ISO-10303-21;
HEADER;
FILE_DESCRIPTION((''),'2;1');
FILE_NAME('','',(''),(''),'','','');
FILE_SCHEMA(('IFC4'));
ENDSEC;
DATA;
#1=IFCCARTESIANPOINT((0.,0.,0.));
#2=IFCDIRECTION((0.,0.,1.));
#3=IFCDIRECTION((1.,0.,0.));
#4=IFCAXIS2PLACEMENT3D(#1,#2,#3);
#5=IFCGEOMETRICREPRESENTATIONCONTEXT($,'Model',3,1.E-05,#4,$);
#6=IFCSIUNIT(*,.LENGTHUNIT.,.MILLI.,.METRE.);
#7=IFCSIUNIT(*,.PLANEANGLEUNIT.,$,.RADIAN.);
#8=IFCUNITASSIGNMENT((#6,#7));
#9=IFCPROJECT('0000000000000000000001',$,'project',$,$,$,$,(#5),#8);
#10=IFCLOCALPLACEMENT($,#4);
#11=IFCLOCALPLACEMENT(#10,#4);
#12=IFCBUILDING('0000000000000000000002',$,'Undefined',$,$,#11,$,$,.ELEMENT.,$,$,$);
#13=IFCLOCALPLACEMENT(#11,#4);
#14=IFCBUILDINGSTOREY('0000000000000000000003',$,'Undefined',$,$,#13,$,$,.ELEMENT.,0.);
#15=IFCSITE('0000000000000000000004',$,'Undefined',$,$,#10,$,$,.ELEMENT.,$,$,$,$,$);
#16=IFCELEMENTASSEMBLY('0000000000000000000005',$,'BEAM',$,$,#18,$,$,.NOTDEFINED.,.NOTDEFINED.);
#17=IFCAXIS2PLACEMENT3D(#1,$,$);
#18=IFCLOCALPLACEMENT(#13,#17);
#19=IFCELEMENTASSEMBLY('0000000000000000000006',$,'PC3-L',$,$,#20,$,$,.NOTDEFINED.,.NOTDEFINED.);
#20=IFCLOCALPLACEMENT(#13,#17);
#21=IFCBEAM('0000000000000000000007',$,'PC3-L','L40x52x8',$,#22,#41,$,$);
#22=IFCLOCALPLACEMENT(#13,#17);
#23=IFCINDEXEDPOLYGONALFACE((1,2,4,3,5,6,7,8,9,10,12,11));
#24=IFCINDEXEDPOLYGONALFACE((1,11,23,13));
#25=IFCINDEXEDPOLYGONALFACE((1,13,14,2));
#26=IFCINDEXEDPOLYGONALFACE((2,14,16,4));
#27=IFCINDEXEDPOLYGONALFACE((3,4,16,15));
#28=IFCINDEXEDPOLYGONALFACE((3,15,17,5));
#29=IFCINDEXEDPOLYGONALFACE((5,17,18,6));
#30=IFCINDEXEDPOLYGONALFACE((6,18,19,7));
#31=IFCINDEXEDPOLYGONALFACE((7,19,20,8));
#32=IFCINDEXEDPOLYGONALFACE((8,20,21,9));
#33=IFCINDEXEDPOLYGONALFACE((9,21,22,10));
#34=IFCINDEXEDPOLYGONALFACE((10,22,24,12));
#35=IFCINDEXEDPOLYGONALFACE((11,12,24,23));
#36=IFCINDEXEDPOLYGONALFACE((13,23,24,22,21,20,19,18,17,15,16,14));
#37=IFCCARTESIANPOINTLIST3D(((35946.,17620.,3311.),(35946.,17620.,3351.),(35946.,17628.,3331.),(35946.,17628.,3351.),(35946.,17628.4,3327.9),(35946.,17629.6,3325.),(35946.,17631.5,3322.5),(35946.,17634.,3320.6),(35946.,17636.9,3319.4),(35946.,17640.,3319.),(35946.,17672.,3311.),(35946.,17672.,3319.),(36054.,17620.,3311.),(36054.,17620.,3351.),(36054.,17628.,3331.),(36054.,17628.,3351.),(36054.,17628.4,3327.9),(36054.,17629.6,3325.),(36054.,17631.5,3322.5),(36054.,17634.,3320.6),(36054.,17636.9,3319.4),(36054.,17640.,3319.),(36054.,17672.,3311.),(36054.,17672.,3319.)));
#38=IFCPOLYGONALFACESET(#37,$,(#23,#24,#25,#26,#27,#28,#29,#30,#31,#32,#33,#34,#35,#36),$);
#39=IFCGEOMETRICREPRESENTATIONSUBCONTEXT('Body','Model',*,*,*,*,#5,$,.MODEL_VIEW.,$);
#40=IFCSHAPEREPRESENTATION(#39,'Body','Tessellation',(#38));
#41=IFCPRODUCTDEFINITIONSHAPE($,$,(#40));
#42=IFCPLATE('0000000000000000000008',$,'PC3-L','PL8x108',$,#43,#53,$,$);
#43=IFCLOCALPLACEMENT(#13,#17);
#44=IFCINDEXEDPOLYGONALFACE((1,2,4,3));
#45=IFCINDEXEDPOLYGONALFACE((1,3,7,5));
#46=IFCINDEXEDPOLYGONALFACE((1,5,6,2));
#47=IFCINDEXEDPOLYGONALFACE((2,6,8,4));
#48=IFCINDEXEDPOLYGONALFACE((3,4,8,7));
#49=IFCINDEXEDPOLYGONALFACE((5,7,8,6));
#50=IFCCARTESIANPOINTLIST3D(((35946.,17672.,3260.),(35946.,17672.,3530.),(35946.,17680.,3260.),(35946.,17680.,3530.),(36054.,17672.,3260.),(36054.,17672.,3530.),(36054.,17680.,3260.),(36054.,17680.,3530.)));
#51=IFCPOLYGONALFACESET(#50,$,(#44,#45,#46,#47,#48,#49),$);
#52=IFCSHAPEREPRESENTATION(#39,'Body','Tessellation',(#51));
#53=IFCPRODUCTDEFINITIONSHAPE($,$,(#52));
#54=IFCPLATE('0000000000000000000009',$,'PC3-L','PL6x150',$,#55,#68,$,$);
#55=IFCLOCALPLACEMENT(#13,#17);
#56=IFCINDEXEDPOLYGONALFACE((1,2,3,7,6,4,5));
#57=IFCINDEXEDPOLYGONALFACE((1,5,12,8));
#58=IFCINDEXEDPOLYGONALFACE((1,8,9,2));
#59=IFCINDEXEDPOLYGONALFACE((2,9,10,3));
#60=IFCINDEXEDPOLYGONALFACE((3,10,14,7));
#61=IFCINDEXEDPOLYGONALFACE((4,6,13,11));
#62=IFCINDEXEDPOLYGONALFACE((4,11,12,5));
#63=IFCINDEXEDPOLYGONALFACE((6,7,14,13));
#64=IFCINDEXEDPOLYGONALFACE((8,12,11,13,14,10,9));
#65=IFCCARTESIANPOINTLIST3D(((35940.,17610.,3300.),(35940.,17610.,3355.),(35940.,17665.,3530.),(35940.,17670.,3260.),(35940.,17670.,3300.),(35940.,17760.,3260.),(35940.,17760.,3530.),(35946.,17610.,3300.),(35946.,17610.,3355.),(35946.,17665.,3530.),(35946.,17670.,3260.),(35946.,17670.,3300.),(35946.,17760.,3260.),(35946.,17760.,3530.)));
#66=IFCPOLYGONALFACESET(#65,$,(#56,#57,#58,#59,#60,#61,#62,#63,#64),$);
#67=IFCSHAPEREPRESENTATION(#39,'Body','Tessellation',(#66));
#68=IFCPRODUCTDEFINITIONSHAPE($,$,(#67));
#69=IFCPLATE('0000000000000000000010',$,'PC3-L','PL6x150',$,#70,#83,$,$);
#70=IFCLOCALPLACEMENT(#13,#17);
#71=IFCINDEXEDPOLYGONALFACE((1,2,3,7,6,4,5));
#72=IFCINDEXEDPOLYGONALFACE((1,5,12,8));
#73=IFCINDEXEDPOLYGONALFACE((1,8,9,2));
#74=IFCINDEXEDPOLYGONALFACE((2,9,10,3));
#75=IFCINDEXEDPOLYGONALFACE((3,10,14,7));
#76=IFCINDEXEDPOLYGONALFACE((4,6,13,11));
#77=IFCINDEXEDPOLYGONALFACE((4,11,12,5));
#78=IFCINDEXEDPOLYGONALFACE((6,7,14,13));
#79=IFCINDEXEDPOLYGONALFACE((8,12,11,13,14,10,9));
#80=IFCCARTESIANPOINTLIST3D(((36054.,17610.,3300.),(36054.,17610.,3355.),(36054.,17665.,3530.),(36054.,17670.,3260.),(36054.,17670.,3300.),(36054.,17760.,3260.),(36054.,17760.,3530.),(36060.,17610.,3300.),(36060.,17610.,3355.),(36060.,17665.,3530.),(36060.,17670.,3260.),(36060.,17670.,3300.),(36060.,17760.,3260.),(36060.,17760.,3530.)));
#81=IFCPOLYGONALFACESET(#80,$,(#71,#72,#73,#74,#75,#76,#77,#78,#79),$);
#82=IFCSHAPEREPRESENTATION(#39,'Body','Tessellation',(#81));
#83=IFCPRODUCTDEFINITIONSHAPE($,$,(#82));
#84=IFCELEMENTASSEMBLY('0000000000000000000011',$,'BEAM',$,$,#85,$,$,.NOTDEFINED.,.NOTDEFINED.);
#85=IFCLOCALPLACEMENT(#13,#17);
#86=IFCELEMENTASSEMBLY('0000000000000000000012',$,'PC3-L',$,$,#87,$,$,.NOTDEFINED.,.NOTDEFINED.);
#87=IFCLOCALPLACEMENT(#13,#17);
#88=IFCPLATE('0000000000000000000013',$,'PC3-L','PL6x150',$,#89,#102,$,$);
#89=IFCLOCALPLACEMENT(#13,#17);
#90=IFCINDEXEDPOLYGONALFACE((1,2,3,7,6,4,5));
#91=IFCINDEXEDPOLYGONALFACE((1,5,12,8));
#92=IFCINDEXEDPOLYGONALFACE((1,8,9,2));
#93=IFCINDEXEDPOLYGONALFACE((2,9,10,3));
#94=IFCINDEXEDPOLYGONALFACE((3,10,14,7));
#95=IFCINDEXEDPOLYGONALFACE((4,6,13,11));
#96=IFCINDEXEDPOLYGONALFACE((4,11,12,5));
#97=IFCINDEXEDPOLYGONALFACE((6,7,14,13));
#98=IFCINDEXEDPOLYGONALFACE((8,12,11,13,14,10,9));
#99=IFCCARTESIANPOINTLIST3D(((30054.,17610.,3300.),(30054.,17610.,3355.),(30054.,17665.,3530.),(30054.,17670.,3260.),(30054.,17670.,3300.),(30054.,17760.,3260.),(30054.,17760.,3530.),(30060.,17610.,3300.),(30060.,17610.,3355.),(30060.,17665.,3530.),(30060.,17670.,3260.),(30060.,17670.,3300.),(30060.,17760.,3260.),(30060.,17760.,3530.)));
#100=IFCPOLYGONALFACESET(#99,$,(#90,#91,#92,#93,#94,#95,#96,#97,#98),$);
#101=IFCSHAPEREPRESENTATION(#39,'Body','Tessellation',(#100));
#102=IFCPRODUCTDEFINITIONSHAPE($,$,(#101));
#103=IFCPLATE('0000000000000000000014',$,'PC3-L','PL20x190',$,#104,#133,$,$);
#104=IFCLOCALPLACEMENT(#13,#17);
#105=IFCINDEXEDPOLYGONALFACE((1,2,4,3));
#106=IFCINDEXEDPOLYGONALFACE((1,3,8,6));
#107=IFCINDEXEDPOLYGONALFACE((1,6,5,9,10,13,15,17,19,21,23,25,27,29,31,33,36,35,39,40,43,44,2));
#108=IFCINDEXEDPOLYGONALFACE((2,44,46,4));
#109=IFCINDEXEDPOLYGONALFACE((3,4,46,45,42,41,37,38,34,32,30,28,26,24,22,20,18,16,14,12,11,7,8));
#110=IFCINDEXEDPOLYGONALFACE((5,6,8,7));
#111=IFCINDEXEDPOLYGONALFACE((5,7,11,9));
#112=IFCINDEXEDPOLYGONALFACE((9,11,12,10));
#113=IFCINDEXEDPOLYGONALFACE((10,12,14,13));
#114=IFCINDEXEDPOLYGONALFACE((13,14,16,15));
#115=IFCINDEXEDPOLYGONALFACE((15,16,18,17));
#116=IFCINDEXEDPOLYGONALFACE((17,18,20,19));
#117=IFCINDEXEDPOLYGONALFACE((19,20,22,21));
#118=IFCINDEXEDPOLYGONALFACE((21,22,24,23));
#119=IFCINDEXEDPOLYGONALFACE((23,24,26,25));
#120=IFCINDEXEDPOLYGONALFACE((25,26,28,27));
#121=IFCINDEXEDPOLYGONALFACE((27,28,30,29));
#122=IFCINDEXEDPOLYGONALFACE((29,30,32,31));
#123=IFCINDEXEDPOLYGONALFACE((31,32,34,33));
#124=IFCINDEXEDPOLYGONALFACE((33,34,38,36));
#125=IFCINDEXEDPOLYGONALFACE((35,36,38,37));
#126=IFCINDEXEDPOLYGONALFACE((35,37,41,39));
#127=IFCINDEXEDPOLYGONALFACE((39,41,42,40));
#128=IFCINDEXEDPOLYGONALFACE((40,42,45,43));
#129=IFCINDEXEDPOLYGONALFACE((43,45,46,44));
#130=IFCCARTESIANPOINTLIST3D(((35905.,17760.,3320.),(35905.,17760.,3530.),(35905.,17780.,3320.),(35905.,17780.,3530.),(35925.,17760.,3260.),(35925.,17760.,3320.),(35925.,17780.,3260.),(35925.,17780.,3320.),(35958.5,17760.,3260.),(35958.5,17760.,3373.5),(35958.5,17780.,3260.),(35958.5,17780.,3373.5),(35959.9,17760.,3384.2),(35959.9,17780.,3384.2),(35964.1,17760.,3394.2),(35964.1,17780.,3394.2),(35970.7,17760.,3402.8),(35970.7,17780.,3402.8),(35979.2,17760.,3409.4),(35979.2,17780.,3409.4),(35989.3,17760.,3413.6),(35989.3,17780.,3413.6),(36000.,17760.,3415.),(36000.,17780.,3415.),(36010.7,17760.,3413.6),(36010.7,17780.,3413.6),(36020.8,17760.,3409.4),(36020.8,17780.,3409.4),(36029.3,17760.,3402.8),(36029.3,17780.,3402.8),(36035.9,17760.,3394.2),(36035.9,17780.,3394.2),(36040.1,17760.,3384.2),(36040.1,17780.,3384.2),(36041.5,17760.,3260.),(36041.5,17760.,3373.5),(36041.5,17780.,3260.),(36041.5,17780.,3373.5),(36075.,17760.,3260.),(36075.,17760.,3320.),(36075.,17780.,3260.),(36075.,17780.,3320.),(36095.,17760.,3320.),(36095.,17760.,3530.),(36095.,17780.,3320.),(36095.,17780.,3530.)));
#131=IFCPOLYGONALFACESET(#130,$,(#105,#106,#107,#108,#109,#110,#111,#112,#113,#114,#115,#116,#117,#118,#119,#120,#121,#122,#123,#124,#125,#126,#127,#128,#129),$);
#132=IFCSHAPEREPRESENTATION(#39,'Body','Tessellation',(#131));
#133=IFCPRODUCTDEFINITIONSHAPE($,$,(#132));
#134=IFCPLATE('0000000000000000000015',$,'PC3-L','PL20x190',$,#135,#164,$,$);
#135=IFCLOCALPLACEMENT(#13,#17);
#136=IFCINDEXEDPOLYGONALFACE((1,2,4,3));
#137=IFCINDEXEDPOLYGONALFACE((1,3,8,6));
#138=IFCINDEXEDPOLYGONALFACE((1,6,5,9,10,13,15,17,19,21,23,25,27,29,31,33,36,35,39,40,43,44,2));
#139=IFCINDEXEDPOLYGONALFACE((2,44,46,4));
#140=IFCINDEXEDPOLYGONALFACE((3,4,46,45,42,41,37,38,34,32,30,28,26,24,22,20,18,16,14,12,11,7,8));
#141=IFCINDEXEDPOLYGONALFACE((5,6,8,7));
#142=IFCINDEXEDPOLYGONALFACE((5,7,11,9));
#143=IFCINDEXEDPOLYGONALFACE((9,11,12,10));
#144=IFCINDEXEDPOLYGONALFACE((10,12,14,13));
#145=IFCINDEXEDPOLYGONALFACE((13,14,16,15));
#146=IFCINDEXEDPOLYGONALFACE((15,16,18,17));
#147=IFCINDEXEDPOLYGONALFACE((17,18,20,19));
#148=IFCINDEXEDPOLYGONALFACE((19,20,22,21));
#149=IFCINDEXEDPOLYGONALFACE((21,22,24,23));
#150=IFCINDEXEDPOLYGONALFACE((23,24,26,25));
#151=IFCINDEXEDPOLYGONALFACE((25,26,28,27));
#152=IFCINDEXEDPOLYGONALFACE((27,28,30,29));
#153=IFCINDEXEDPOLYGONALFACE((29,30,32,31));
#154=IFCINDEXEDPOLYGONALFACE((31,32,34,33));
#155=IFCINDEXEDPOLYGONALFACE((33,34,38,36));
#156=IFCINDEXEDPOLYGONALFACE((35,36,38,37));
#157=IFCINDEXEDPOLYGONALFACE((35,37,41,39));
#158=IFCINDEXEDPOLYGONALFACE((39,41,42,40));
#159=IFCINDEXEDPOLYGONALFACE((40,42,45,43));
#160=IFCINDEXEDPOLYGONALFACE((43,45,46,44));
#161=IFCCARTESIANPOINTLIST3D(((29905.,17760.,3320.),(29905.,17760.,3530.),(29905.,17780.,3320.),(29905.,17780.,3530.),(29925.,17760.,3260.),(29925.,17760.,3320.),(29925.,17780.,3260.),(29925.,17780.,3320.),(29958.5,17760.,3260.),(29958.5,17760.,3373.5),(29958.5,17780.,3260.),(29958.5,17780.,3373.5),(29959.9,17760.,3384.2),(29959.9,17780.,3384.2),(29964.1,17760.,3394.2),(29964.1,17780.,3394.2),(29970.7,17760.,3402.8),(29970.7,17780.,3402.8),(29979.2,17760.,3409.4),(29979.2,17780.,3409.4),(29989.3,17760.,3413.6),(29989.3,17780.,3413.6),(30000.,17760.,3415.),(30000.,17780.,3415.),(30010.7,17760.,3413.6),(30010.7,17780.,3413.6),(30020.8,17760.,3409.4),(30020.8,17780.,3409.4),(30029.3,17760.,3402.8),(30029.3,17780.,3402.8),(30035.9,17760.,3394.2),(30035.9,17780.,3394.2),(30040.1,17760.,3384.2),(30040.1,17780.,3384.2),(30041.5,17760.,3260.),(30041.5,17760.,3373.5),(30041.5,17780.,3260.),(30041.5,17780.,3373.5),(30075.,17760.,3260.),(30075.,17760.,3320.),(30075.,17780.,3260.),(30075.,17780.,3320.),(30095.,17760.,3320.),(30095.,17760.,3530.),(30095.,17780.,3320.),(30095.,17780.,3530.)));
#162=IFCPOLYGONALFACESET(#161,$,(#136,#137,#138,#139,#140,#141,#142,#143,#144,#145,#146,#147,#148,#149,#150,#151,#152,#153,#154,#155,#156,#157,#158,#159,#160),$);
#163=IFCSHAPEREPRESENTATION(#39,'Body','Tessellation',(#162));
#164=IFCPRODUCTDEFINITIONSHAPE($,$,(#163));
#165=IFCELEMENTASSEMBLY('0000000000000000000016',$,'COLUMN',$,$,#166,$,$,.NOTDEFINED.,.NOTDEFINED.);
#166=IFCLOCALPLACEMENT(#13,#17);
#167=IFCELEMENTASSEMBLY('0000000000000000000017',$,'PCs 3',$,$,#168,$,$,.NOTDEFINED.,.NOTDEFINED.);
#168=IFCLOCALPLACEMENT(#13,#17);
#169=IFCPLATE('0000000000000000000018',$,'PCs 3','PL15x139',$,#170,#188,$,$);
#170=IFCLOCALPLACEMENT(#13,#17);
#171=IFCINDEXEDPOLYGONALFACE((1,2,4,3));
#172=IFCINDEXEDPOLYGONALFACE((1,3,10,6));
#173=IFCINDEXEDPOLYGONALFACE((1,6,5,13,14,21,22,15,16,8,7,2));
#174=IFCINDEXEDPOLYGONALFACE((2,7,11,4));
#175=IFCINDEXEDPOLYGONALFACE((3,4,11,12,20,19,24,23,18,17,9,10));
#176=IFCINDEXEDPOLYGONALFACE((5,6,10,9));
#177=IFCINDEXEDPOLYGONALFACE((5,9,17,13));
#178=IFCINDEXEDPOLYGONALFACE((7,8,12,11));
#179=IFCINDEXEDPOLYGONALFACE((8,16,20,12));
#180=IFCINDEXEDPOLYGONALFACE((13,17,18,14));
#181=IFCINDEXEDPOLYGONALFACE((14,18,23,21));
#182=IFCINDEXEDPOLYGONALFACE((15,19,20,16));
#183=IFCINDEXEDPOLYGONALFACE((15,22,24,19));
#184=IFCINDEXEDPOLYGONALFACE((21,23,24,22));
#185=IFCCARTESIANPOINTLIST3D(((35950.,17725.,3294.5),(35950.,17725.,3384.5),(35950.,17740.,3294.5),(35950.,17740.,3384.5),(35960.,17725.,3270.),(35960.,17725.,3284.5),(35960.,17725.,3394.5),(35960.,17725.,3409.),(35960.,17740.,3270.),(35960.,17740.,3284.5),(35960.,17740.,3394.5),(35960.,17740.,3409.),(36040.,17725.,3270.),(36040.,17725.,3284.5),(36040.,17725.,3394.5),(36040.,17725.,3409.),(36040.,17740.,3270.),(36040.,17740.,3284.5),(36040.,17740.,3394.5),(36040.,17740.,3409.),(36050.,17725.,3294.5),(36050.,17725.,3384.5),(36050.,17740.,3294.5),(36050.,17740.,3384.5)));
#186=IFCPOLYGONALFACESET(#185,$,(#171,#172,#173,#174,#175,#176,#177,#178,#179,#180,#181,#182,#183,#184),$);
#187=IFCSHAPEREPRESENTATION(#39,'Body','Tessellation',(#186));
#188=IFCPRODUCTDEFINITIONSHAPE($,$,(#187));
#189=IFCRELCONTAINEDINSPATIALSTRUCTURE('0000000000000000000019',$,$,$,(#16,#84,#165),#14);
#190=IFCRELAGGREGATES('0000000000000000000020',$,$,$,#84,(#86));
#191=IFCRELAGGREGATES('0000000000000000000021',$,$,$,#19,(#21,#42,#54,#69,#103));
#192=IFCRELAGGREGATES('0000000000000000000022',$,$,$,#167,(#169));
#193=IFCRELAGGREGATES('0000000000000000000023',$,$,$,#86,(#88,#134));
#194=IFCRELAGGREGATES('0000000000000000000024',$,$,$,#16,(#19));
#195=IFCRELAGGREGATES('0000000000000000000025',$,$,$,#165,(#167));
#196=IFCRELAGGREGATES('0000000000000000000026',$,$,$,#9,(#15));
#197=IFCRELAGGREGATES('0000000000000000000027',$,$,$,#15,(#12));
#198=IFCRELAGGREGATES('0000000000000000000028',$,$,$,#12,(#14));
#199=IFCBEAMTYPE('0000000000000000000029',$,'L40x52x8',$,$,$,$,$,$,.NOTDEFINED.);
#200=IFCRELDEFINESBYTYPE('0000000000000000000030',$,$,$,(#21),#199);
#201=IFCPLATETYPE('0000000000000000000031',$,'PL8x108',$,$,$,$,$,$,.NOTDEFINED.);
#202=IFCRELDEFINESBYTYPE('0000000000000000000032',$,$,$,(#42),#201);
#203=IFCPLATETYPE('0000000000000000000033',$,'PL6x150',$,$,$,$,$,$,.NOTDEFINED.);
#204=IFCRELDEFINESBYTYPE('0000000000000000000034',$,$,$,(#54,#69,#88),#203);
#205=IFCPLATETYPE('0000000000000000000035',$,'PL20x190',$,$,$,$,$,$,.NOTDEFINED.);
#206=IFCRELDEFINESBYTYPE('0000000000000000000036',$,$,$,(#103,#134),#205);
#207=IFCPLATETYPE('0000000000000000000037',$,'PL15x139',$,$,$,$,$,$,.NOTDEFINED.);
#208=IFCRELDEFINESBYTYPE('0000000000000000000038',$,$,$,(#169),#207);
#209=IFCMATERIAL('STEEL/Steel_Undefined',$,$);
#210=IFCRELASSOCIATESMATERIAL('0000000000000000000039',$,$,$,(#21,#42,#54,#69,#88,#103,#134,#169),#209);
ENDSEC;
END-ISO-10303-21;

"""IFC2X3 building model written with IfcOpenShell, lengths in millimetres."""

from ifc_helpers import new_model, si_unit, frame, frame_2d, origin_with_axes, origin_2d_with_axis, place, context, subcontext, project, spatial, polyline, circle_curve, parameter, trimmed, segment, composite_curve, l_section, outline, extrude, material, type_object, element, aggregate, save


model = new_model("IFC2X3")

# Units and contexts
model_context = context("Model", 3, precision=1e-05, world=origin_with_axes())
body_context = subcontext(model_context, "Body", "Model", "MODEL_VIEW")
ifc_project = project(units=[si_unit("LENGTHUNIT", "METRE", prefix="MILLI"), si_unit("PLANEANGLEUNIT", "RADIAN")], contexts=[model_context])

# Site, building, storey
site_placement = place(None, origin_with_axes())
site = spatial("IfcSite", under=ifc_project, at=site_placement, Name="Undefined", CompositionType="ELEMENT")
building_placement = place(site_placement, origin_with_axes())
building = spatial("IfcBuilding", under=site, at=building_placement, Name="Undefined", CompositionType="ELEMENT")
storey_placement = place(building_placement, origin_with_axes())
storey = spatial("IfcBuildingStorey", under=building, at=storey_placement, Name="Undefined", CompositionType="ELEMENT", Elevation=0.0)

# Element assemblies, beam, plates
assembly_1_placement = place(storey_placement, origin_with_axes())
assembly_1 = element("IfcElementAssembly", 1, at=assembly_1_placement, inside=storey, Name="BEAM", AssemblyPlace="NOTDEFINED", PredefinedType="NOTDEFINED")
assembly_2_placement = place(assembly_1_placement, origin_with_axes())
assembly_2 = element("IfcElementAssembly", 2, at=assembly_2_placement, Name="PC3-L", AssemblyPlace="NOTDEFINED", PredefinedType="NOTDEFINED")
ifc_material_1 = material(Name="STEEL/Steel_Undefined")
beam_type = type_object("IfcBeamType", Name="L40x52x8", PredefinedType="NOTDEFINED")
beam_placement = place(assembly_2_placement, frame((36054.0, 17646.0, 3331.0), z_axis=(0.0, 0.0, 1.0), x_axis=(-1.0, 0.0, 0.0)))
beam = element("IfcBeam", 3, at=beam_placement, type_object=beam_type, material=ifc_material_1, Name="PC3-L", Description="L40x52x8", context=body_context, shape_type="SweptSolid", body=[
    extrude(l_section(Depth=40.0, Width=52.0, Thickness=8.0, FilletRadius=12.0, at=origin_2d_with_axis()), frame((108.0, 0.0, 0.0), z_axis=(-1.0, 0.0, 0.0), x_axis=(0.0, -1.0, 0.0)), (0.0, 0.0, 1.0), 108.0),
])
plate_type_1 = type_object("IfcPlateType", Name="PL8x108", PredefinedType="NOTDEFINED")
plate_1_placement = place(assembly_2_placement, frame((36054.0, 17676.0, 3260.0), z_axis=(0.0, 1.0, 0.0), x_axis=(-1.0, 0.0, 0.0)))
plate_1 = element("IfcPlate", 4, at=plate_1_placement, type_object=plate_type_1, material=ifc_material_1, Name="PC3-L", Description="PL8x108", context=body_context, shape_type="SweptSolid", body=[
    extrude(outline(polyline([(0.0, 0.0), (108.0, 0.0), (108.0, 270.0), (0.0, 270.0), (0.0, 0.0)])), frame((0.0, 0.0, -4.0), z_axis=(0.0, 0.0, 1.0), x_axis=(1.0, 0.0, 0.0)), (0.0, 0.0, 1.0), 8.0),
])
plate_type_2 = type_object("IfcPlateType", Name="PL6x150", PredefinedType="NOTDEFINED")
plate_2_placement = place(assembly_2_placement, frame((35943.0, 17670.0, 3260.0), z_axis=(-1.0, 0.0, 0.0), x_axis=(0.0, 0.0, 1.0)))
plate_2 = element("IfcPlate", 5, at=plate_2_placement, type_object=plate_type_2, material=ifc_material_1, Name="PC3-L", Description="PL6x150", context=body_context, shape_type="SweptSolid", body=[
    extrude(outline(polyline([(0.0, 0.0), (40.0, 0.0), (40.0, -60.0), (95.0, -60.0), (270.0, -5.0), (270.0, 90.0), (0.0, 90.0), (0.0, 0.0)])), frame((0.0, 0.0, -3.0), z_axis=(0.0, 0.0, 1.0), x_axis=(1.0, 0.0, 0.0)), (0.0, 0.0, 1.0), 6.0),
])
plate_3_placement = place(assembly_2_placement, frame((36057.0, 17670.0, 3260.0), z_axis=(-1.0, 0.0, 0.0), x_axis=(0.0, 0.0, 1.0)))
plate_3 = element("IfcPlate", 6, at=plate_3_placement, type_object=plate_type_2, material=ifc_material_1, Name="PC3-L", Description="PL6x150", context=body_context, shape_type="SweptSolid", body=[
    extrude(outline(polyline([(0.0, 0.0), (40.0, 0.0), (40.0, -60.0), (95.0, -60.0), (270.0, -5.0), (270.0, 90.0), (0.0, 90.0), (0.0, 0.0)])), frame((0.0, 0.0, -3.0), z_axis=(0.0, 0.0, 1.0), x_axis=(1.0, 0.0, 0.0)), (0.0, 0.0, 1.0), 6.0),
])

# Element assemblies, plate
assembly_3_placement = place(storey_placement, origin_with_axes())
assembly_3 = element("IfcElementAssembly", 7, at=assembly_3_placement, inside=storey, Name="BEAM", AssemblyPlace="NOTDEFINED", PredefinedType="NOTDEFINED")
assembly_4_placement = place(assembly_3_placement, origin_with_axes())
assembly_4 = element("IfcElementAssembly", 8, at=assembly_4_placement, Name="PC3-L", AssemblyPlace="NOTDEFINED", PredefinedType="NOTDEFINED")
aggregate(assembly_3, [assembly_4])
plate_4_placement = place(assembly_4_placement, frame((30057.0, 17670.0, 3260.0), z_axis=(-1.0, 0.0, 0.0), x_axis=(0.0, 0.0, 1.0)))
plate_4 = element("IfcPlate", 9, at=plate_4_placement, type_object=plate_type_2, material=ifc_material_1, Name="PC3-L", Description="PL6x150", context=body_context, shape_type="SweptSolid", body=[
    extrude(outline(polyline([(0.0, 0.0), (40.0, 0.0), (40.0, -60.0), (95.0, -60.0), (270.0, -5.0), (270.0, 90.0), (0.0, 90.0), (0.0, 0.0)])), frame((0.0, 0.0, -3.0), z_axis=(0.0, 0.0, 1.0), x_axis=(1.0, 0.0, 0.0)), (0.0, 0.0, 1.0), 6.0),
])

# Plates
plate_type_3 = type_object("IfcPlateType", Name="PL20x190", PredefinedType="NOTDEFINED")
plate_5_placement = place(assembly_2_placement, frame((36095.0, 17770.0, 3260.0), z_axis=(0.0, 1.0, 0.0), x_axis=(-1.0, 0.0, 0.0)))
plate_5 = element("IfcPlate", 10, at=plate_5_placement, type_object=plate_type_3, material=ifc_material_1, Name="PC3-L", Description="PL20x190", context=body_context, shape_type="SweptSolid", body=[
    extrude(outline(composite_curve([segment(polyline([(0.0, 60.0), (20.0, 60.0), (20.0, 0.0), (53.5, 0.0), (53.5, 113.5)]), True, "CONTINUOUS"), segment(trimmed(circle_curve(frame_2d((95.0, 113.5), x_axis=(-1.0, 0.0)), 41.5), [parameter(0.0)], [parameter(4.712389)], False, "PARAMETER"), True, "CONTINUOUS"), segment(polyline([(95.0, 155.0), (95.0, 155.0)]), True, "CONTINUOUS"), segment(trimmed(circle_curve(frame_2d((95.0, 113.5), x_axis=(0.0, 1.0)), 41.5), [parameter(0.0)], [parameter(4.712389)], False, "PARAMETER"), True, "CONTINUOUS"), segment(polyline([(136.5, 113.5), (136.5, 0.0), (170.0, 0.0), (170.0, 60.0), (190.0, 60.0), (190.0, 270.0), (0.0, 270.0), (0.0, 60.0)]), True, "CONTINUOUS")], self_intersect=True)), frame((0.0, 0.0, -10.0), z_axis=(0.0, 0.0, 1.0), x_axis=(1.0, 0.0, 0.0)), (0.0, 0.0, 1.0), 20.0),
])
plate_6_placement = place(assembly_4_placement, frame((30095.0, 17770.0, 3260.0), z_axis=(0.0, 1.0, 0.0), x_axis=(-1.0, 0.0, 0.0)))
plate_6 = element("IfcPlate", 11, at=plate_6_placement, type_object=plate_type_3, material=ifc_material_1, Name="PC3-L", Description="PL20x190", context=body_context, shape_type="SweptSolid", body=[
    extrude(outline(composite_curve([segment(polyline([(0.0, 60.0), (20.0, 60.0), (20.0, 0.0), (53.5, 0.0), (53.5, 113.5)]), True, "CONTINUOUS"), segment(trimmed(circle_curve(frame_2d((95.0, 113.5), x_axis=(-1.0, 0.0)), 41.5), [parameter(0.0)], [parameter(4.712389)], False, "PARAMETER"), True, "CONTINUOUS"), segment(polyline([(95.0, 155.0), (95.0, 155.0)]), True, "CONTINUOUS"), segment(trimmed(circle_curve(frame_2d((95.0, 113.5), x_axis=(0.0, 1.0)), 41.5), [parameter(0.0)], [parameter(4.712389)], False, "PARAMETER"), True, "CONTINUOUS"), segment(polyline([(136.5, 113.5), (136.5, 0.0), (170.0, 0.0), (170.0, 60.0), (190.0, 60.0), (190.0, 270.0), (0.0, 270.0), (0.0, 60.0)]), True, "CONTINUOUS")], self_intersect=True)), frame((0.0, 0.0, -10.0), z_axis=(0.0, 0.0, 1.0), x_axis=(1.0, 0.0, 0.0)), (0.0, 0.0, 1.0), 20.0),
])

# Element assemblies, plate
assembly_5_placement = place(storey_placement, origin_with_axes())
assembly_5 = element("IfcElementAssembly", 12, at=assembly_5_placement, inside=storey, Name="COLUMN", AssemblyPlace="NOTDEFINED", PredefinedType="NOTDEFINED")
assembly_6_placement = place(assembly_5_placement, origin_with_axes())
assembly_6 = element("IfcElementAssembly", 13, at=assembly_6_placement, Name="PCs 3", AssemblyPlace="NOTDEFINED", PredefinedType="NOTDEFINED")
plate_type_4 = type_object("IfcPlateType", Name="PL15x139", PredefinedType="NOTDEFINED")
plate_7_placement = place(assembly_6_placement, frame((35960.0, 17732.5, 3409.0), z_axis=(0.0, -1.0, 0.0), x_axis=(0.0, 0.0, -1.0)))
plate_7 = element("IfcPlate", 14, at=plate_7_placement, type_object=plate_type_4, material=ifc_material_1, Name="PCs 3", Description="PL15x139", context=body_context, shape_type="SweptSolid", body=[
    extrude(outline(polyline([(0.0, 0.0), (14.5, 0.0), (24.5, -10.0), (114.5, -10.0), (124.5, 0.0), (139.0, 0.0), (139.0, 80.0), (124.5, 80.0), (114.5, 90.0), (24.5, 90.0), (14.5, 80.0), (0.0, 80.0), (0.0, 0.0)])), frame((0.0, 0.0, -7.5), z_axis=(0.0, 0.0, 1.0), x_axis=(1.0, 0.0, 0.0)), (0.0, 0.0, 1.0), 15.0),
])

aggregate(assembly_2, [beam, plate_1, plate_2, plate_3, plate_5])
aggregate(assembly_6, [plate_7])
aggregate(assembly_4, [plate_4, plate_6])

aggregate(assembly_1, [assembly_2])

aggregate(assembly_5, [assembly_6])

save(model, "model.ifc")
